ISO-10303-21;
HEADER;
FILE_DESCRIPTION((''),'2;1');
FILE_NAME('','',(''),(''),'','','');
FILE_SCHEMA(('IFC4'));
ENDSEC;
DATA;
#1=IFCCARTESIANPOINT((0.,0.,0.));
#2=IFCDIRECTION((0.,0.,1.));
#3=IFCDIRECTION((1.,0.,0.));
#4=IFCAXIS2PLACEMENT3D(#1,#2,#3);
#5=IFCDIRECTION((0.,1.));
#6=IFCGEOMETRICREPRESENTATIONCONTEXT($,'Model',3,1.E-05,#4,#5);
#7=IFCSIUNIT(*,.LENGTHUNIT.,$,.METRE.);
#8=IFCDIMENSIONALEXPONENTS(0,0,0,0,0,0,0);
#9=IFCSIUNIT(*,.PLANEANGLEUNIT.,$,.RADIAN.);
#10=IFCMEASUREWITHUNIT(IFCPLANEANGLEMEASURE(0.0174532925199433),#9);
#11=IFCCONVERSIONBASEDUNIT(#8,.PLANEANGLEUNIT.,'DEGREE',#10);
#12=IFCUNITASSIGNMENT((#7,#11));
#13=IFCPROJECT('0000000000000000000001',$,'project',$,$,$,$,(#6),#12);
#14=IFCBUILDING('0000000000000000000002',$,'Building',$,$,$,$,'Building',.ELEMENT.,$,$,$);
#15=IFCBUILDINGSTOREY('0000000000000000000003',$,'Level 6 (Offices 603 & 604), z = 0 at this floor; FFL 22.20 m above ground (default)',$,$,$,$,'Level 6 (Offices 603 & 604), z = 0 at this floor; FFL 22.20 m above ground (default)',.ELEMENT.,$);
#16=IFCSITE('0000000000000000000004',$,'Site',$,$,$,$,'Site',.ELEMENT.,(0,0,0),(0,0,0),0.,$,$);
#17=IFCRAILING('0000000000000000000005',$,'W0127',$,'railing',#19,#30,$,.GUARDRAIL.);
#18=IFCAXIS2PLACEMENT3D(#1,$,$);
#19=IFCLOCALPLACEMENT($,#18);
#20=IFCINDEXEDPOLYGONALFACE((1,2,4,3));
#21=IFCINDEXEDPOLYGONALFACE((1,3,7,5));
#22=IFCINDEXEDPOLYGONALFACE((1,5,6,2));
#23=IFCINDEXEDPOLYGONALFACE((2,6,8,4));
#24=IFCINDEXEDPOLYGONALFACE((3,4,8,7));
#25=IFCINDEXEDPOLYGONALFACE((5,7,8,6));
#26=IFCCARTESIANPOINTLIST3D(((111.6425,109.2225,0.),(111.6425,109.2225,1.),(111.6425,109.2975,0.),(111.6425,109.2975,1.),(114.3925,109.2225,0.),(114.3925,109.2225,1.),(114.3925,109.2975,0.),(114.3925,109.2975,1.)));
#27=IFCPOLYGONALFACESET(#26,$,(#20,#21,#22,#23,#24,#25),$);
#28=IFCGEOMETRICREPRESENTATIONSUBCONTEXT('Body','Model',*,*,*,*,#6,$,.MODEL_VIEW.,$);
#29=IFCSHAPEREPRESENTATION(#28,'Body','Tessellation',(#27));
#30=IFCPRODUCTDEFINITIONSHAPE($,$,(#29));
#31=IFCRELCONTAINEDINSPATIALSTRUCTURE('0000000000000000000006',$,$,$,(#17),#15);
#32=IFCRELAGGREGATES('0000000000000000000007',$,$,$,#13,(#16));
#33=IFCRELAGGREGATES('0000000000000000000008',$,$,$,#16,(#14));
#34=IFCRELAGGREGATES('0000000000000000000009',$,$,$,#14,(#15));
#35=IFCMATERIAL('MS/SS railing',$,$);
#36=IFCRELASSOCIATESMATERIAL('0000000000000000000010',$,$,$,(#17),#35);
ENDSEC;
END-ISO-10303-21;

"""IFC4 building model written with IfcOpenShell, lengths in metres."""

from ifc_helpers import new_model, entity, si_unit, converted_unit, direction, frame, frame_2d, origin_with_axes, place, context, subcontext, project, spatial, rectangle, extrude, material, element, save


model = new_model("IFC4")

# Units and contexts
model_context = context("Model", 3, precision=1e-05, world=origin_with_axes(), true_north=direction((0.0, 1.0)))
body_context = subcontext(model_context, "Body", "Model", "MODEL_VIEW")
ifc_project = project(units=[si_unit("LENGTHUNIT", "METRE"), converted_unit("PLANEANGLEUNIT", "DEGREE", entity("IfcPlaneAngleMeasure", 0.0174532925199433), si_unit("PLANEANGLEUNIT", "RADIAN"), dimensions=[0, 0, 0, 0, 0, 0, 0])], contexts=[model_context])

# Site, building, storey
site = spatial("IfcSite", under=ifc_project, Name="Site", LongName="Site", CompositionType="ELEMENT", RefLatitude=(0, 0, 0), RefLongitude=(0, 0, 0), RefElevation=0.0)
building = spatial("IfcBuilding", under=site, Name="Building", LongName="Building", CompositionType="ELEMENT")
storey = spatial("IfcBuildingStorey", under=building, Name="Level 6 (Offices 603 & 604), z = 0 at this floor; FFL 22.20 m above ground (default)", LongName="Level 6 (Offices 603 & 604), z = 0 at this floor; FFL 22.20 m above ground (default)", CompositionType="ELEMENT")

# Shared definitions
placement = place(None, origin_with_axes())

# Railing
ifc_material_1 = material(Name="MS/SS railing")
element("IfcRailing", 1, at=placement, inside=storey, material=ifc_material_1, Name="W0127", ObjectType="railing", PredefinedType="GUARDRAIL", context=body_context, shape_type="SweptSolid", body=[
    extrude(rectangle(XDim=2.75, YDim=0.075, at=frame_2d((0.0, 0.0), x_axis=(1.0, 0.0))), frame((113.0175, 109.26, 0.0), z_axis=(0.0, 0.0, 1.0), x_axis=(1.0, 0.0, 0.0)), (0.0, 0.0, 1.0), 1.0),
])

save(model, "model.ifc")
